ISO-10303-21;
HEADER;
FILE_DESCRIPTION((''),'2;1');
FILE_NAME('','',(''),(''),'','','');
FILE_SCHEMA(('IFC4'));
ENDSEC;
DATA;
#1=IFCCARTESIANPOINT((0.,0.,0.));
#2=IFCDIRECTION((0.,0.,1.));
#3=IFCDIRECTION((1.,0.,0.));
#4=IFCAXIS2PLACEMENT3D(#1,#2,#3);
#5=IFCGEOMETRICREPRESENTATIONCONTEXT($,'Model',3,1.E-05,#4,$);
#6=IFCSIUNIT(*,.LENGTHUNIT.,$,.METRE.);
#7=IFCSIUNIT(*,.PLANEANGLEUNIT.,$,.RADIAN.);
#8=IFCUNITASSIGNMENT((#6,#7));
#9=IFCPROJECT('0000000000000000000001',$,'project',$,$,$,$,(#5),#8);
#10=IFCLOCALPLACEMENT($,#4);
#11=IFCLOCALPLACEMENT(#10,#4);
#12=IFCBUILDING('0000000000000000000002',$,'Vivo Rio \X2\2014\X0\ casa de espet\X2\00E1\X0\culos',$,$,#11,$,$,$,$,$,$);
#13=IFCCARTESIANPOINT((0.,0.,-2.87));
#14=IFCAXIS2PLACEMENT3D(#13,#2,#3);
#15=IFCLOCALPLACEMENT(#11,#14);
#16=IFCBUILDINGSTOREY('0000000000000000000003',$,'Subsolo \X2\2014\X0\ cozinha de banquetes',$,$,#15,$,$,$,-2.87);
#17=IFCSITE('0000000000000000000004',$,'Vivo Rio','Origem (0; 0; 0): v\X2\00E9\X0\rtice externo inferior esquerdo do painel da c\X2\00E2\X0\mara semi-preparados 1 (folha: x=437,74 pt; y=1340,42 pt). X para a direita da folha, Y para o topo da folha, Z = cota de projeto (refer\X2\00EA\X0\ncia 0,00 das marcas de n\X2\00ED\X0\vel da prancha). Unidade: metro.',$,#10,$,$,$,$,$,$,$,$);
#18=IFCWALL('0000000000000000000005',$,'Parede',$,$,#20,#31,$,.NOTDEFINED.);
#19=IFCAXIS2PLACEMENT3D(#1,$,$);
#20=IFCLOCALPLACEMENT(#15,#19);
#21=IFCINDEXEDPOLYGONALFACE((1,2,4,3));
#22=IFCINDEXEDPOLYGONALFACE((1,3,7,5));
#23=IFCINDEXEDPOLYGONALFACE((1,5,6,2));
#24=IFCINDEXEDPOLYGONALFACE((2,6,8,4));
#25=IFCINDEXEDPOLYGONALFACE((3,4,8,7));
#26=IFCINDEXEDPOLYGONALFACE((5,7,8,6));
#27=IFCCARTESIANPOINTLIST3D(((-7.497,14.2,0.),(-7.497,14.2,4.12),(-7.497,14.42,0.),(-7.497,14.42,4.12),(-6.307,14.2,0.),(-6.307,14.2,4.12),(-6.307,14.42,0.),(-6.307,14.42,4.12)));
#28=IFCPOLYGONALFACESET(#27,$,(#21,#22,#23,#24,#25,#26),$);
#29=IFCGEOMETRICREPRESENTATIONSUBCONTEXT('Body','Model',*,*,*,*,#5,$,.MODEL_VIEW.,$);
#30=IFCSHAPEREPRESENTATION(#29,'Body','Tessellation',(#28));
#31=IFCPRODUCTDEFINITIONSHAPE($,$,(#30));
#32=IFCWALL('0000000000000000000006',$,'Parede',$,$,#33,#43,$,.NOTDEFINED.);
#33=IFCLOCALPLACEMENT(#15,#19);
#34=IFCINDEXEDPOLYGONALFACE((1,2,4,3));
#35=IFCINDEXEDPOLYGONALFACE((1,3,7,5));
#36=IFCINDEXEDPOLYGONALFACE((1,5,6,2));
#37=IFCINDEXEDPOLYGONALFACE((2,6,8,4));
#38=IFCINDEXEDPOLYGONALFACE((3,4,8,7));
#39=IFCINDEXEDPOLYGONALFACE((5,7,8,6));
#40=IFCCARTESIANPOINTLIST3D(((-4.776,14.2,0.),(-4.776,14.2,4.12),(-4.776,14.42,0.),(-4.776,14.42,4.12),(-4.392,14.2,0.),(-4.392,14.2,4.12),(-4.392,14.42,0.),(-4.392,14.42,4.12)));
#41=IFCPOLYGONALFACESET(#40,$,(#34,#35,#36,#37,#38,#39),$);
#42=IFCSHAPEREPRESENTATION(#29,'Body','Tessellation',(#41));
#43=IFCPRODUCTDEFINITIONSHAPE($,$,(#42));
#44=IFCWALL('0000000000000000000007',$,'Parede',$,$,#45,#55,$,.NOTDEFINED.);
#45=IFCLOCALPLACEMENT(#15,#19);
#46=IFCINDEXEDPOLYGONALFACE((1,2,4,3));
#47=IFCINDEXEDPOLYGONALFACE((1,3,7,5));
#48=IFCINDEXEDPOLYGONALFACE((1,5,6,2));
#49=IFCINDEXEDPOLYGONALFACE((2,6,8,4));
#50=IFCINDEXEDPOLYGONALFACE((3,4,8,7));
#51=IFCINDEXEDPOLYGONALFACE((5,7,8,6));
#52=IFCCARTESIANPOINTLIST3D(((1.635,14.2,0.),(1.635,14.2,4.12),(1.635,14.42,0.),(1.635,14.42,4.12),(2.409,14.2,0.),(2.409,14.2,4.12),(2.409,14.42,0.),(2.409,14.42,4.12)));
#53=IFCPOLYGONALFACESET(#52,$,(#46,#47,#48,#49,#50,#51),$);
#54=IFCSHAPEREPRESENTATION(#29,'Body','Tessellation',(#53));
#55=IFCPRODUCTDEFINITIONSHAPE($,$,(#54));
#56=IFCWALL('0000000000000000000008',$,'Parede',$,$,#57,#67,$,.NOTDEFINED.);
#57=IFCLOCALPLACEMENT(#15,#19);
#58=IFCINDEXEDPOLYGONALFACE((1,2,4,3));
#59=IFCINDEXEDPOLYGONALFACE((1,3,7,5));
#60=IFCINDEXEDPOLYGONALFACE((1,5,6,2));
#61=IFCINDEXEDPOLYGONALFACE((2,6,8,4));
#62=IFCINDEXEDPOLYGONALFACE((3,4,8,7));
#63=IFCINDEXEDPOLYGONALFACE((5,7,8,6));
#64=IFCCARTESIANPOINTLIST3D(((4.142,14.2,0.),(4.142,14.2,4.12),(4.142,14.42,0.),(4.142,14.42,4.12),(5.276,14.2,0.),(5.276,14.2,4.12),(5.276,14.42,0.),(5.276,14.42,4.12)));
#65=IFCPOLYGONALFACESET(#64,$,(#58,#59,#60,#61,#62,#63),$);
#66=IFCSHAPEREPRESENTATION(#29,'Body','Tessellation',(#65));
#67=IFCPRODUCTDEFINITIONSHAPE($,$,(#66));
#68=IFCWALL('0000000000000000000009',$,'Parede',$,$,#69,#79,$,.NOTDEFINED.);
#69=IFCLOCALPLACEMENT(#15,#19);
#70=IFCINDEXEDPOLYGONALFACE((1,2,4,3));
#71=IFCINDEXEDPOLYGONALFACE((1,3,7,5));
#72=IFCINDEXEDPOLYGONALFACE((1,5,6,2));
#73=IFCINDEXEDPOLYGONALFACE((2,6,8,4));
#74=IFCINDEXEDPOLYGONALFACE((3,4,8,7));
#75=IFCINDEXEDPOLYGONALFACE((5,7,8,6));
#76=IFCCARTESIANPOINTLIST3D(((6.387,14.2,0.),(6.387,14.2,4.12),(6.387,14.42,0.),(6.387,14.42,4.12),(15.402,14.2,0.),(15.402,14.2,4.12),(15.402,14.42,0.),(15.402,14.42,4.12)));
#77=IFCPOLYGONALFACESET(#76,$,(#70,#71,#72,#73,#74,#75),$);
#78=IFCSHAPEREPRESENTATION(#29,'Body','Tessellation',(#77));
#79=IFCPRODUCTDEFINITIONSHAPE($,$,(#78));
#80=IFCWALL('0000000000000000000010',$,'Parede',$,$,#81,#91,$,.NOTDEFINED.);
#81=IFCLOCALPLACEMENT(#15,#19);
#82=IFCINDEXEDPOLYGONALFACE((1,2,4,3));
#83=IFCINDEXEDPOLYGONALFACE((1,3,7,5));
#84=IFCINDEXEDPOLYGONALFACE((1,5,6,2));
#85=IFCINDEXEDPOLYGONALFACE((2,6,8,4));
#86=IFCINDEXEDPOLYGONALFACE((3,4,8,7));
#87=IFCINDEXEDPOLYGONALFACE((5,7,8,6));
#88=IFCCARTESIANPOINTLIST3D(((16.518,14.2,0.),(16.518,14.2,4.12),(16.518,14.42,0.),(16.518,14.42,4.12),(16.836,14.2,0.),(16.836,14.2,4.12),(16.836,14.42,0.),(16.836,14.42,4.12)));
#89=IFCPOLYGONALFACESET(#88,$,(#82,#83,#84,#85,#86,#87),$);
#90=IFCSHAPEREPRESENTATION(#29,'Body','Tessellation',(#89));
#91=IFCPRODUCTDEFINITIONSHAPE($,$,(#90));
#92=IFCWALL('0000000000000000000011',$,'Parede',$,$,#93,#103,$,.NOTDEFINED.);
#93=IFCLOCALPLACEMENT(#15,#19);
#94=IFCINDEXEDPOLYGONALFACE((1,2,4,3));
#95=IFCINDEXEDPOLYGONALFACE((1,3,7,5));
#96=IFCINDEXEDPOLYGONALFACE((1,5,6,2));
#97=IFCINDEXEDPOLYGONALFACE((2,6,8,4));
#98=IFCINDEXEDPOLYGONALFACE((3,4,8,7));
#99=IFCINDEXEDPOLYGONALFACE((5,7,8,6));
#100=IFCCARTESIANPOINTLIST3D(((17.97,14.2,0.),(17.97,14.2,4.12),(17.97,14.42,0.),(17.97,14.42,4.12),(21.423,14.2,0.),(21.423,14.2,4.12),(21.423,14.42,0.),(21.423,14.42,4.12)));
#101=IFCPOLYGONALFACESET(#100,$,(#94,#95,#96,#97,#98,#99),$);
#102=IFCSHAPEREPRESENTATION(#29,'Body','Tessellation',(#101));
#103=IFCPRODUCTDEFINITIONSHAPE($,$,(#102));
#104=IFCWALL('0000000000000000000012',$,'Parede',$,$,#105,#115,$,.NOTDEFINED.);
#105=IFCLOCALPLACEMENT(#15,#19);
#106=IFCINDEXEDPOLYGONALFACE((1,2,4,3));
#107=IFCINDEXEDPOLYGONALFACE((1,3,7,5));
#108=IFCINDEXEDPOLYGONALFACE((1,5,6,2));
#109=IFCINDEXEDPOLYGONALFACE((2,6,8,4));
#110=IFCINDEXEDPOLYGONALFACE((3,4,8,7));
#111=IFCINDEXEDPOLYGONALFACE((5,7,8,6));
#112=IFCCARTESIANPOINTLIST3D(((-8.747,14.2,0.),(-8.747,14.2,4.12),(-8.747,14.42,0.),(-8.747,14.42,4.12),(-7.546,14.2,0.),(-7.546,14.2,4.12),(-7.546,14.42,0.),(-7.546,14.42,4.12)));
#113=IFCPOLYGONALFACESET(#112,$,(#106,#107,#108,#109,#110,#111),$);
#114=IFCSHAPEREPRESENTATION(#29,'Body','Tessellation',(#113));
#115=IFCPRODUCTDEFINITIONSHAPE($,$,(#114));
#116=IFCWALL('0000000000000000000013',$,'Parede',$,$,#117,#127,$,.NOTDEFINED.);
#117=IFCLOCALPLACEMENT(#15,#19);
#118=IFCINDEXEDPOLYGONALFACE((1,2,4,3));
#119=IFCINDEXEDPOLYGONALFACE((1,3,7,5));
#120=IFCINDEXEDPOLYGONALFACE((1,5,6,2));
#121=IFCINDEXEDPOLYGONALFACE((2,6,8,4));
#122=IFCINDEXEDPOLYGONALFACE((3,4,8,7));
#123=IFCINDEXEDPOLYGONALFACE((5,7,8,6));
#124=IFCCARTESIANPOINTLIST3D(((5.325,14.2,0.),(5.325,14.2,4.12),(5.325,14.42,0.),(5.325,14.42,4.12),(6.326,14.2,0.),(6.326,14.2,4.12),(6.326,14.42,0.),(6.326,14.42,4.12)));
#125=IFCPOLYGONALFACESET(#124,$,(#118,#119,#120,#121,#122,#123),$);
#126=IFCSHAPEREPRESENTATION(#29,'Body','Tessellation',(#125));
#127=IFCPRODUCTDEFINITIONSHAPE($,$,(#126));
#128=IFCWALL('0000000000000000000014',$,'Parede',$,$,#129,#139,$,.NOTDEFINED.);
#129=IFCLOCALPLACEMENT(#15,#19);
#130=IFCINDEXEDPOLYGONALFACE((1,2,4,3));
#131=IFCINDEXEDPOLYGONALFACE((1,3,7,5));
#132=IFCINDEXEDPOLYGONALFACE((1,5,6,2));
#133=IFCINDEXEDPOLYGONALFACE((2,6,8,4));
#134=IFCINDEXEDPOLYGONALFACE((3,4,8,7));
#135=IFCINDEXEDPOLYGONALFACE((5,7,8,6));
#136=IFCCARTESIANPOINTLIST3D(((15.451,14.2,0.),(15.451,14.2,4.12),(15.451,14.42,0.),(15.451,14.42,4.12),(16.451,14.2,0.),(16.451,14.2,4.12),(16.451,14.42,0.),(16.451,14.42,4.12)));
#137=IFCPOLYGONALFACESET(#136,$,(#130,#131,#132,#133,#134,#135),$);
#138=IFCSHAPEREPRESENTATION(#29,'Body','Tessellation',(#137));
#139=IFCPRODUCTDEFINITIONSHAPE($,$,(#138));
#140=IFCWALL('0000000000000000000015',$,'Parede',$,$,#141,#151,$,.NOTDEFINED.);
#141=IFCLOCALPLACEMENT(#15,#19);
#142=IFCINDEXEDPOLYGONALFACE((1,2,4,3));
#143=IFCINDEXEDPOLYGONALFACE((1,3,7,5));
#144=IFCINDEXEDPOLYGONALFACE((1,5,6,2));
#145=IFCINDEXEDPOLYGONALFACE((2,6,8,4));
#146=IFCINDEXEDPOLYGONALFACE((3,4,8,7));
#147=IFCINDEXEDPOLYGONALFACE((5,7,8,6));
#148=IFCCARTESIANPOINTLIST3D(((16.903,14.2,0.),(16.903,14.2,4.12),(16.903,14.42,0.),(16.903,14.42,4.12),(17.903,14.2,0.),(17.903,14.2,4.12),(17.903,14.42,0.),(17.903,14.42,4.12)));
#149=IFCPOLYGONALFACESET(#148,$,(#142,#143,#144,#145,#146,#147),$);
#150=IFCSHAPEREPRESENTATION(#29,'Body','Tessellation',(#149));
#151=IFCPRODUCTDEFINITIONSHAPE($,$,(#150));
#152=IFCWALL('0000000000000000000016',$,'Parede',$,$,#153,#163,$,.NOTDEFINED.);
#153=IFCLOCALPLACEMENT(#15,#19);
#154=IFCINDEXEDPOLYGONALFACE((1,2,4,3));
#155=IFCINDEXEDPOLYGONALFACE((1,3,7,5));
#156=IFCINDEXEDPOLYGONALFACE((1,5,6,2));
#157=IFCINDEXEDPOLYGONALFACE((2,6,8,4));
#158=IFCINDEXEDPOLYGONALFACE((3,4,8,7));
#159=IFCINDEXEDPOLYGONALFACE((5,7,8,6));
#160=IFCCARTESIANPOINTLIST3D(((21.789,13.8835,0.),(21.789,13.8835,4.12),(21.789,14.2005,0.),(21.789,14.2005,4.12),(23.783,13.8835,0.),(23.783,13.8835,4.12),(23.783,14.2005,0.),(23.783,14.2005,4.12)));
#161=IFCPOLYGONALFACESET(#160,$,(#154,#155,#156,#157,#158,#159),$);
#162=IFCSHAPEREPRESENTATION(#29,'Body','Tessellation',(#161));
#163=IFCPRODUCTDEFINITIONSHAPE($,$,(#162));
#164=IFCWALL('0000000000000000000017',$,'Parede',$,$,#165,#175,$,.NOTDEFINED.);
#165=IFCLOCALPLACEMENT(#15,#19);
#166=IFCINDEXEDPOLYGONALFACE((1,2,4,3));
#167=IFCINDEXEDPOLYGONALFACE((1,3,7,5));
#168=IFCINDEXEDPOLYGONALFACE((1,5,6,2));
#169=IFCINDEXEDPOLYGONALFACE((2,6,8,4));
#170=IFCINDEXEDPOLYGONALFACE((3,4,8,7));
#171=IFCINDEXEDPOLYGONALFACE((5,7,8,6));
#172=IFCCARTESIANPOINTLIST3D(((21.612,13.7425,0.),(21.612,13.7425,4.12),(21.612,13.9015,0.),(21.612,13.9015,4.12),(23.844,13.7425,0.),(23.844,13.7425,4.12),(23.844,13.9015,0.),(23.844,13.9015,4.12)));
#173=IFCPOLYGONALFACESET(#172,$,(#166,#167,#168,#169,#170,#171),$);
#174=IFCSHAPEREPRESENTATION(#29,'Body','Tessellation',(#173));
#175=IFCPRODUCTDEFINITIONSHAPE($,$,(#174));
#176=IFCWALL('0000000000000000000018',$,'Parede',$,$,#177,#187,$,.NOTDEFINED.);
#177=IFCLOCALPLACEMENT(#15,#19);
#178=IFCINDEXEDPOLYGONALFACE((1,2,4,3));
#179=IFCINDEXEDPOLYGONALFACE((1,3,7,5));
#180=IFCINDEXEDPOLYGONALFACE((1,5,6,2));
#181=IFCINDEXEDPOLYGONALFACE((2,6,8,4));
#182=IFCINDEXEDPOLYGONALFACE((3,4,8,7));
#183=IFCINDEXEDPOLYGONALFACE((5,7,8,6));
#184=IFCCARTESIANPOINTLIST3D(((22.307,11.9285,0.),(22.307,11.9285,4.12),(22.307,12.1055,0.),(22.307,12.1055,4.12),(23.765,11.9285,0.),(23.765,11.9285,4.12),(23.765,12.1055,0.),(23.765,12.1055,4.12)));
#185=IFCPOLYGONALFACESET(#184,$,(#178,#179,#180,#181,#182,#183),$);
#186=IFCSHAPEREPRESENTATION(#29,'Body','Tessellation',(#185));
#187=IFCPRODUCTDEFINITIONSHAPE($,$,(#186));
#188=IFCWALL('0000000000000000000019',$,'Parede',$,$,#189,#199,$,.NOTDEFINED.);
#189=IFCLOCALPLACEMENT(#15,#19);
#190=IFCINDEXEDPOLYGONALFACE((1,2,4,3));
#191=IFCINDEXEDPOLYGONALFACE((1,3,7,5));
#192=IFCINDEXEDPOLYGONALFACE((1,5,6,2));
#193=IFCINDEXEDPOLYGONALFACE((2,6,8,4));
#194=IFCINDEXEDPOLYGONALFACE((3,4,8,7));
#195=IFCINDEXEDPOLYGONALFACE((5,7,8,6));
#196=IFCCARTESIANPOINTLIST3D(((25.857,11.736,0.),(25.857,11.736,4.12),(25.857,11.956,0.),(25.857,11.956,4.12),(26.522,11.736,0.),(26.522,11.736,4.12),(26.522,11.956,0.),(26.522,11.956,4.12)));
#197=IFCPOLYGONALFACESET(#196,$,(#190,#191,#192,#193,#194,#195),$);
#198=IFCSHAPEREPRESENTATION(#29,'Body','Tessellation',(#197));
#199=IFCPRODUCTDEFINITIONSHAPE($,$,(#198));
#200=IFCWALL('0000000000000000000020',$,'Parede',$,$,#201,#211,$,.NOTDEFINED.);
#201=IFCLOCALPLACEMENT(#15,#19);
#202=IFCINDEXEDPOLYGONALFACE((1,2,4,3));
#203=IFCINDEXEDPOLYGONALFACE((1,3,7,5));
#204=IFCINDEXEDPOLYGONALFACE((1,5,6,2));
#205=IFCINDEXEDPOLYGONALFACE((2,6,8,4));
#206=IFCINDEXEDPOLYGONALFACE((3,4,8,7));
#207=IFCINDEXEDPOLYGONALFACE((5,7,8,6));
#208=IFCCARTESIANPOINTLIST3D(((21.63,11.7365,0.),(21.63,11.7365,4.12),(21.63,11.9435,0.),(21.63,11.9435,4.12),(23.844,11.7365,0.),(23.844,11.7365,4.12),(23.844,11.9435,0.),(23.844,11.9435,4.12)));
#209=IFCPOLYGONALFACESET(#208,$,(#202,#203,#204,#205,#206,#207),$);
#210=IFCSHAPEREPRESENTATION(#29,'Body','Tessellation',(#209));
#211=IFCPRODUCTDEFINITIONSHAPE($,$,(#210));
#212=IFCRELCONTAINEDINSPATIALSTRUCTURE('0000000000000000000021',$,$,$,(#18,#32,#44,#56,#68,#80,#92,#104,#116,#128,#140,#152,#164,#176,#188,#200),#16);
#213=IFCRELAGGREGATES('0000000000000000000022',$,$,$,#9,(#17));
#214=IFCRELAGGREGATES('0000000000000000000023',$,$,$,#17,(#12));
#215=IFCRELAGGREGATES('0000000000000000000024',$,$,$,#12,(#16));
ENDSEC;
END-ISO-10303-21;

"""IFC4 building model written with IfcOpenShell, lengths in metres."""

from ifc_helpers import new_model, si_unit, frame, origin_with_axes, origin_2d, place, context, subcontext, project, spatial, rectangle, extrude, element, save


model = new_model("IFC4")

# Units and contexts
model_context = context("Model", 3, precision=1e-05, world=origin_with_axes())
body_context = subcontext(model_context, "Body", "Model", "MODEL_VIEW")
ifc_project = project(units=[si_unit("LENGTHUNIT", "METRE"), si_unit("PLANEANGLEUNIT", "RADIAN")], contexts=[model_context])

# Site, building, storey
site_placement = place(None, origin_with_axes())
site = spatial("IfcSite", under=ifc_project, at=site_placement, Name="Vivo Rio", Description="Origem (0; 0; 0): vértice externo inferior esquerdo do painel da câmara semi-preparados 1 (folha: x=437,74 pt; y=1340,42 pt). X para a direita da folha, Y para o topo da folha, Z = cota de projeto (referência 0,00 das marcas de nível da prancha). Unidade: metro.")
building_placement = place(site_placement, origin_with_axes())
building = spatial("IfcBuilding", under=site, at=building_placement, Name="Vivo Rio — casa de espetáculos")
storey_placement = place(building_placement, frame((0.0, 0.0, -2.87), z_axis=(0.0, 0.0, 1.0), x_axis=(1.0, 0.0, 0.0)))
storey = spatial("IfcBuildingStorey", under=building, at=storey_placement, Name="Subsolo — cozinha de banquetes", Elevation=-2.87)

# Walls
wall_1_placement = place(storey_placement, origin_with_axes())
element("IfcWall", 1, at=wall_1_placement, inside=storey, Name="Parede", PredefinedType="NOTDEFINED", context=body_context, shape_type="SweptSolid", body=[
    extrude(rectangle(XDim=1.19, YDim=0.22, at=origin_2d()), frame((-6.902, 14.31, 0.0), z_axis=(0.0, 0.0, 1.0), x_axis=(1.0, 0.0, 0.0)), (0.0, 0.0, 1.0), 4.12),
])
wall_2_placement = place(storey_placement, origin_with_axes())
element("IfcWall", 2, at=wall_2_placement, inside=storey, Name="Parede", PredefinedType="NOTDEFINED", context=body_context, shape_type="SweptSolid", body=[
    extrude(rectangle(XDim=0.384, YDim=0.22, at=origin_2d()), frame((-4.584, 14.31, 0.0), z_axis=(0.0, 0.0, 1.0), x_axis=(1.0, 0.0, 0.0)), (0.0, 0.0, 1.0), 4.12),
])
wall_3_placement = place(storey_placement, origin_with_axes())
element("IfcWall", 3, at=wall_3_placement, inside=storey, Name="Parede", PredefinedType="NOTDEFINED", context=body_context, shape_type="SweptSolid", body=[
    extrude(rectangle(XDim=0.774, YDim=0.22, at=origin_2d()), frame((2.022, 14.31, 0.0), z_axis=(0.0, 0.0, 1.0), x_axis=(1.0, 0.0, 0.0)), (0.0, 0.0, 1.0), 4.12),
])
wall_4_placement = place(storey_placement, origin_with_axes())
element("IfcWall", 4, at=wall_4_placement, inside=storey, Name="Parede", PredefinedType="NOTDEFINED", context=body_context, shape_type="SweptSolid", body=[
    extrude(rectangle(XDim=1.134, YDim=0.22, at=origin_2d()), frame((4.709, 14.31, 0.0), z_axis=(0.0, 0.0, 1.0), x_axis=(1.0, 0.0, 0.0)), (0.0, 0.0, 1.0), 4.12),
])
wall_5_placement = place(storey_placement, origin_with_axes())
element("IfcWall", 5, at=wall_5_placement, inside=storey, Name="Parede", PredefinedType="NOTDEFINED", context=body_context, shape_type="SweptSolid", body=[
    extrude(rectangle(XDim=9.015, YDim=0.22, at=origin_2d()), frame((10.8945, 14.31, 0.0), z_axis=(0.0, 0.0, 1.0), x_axis=(1.0, 0.0, 0.0)), (0.0, 0.0, 1.0), 4.12),
])
wall_6_placement = place(storey_placement, origin_with_axes())
element("IfcWall", 6, at=wall_6_placement, inside=storey, Name="Parede", PredefinedType="NOTDEFINED", context=body_context, shape_type="SweptSolid", body=[
    extrude(rectangle(XDim=0.318, YDim=0.22, at=origin_2d()), frame((16.677, 14.31, 0.0), z_axis=(0.0, 0.0, 1.0), x_axis=(1.0, 0.0, 0.0)), (0.0, 0.0, 1.0), 4.12),
])
wall_7_placement = place(storey_placement, origin_with_axes())
element("IfcWall", 7, at=wall_7_placement, inside=storey, Name="Parede", PredefinedType="NOTDEFINED", context=body_context, shape_type="SweptSolid", body=[
    extrude(rectangle(XDim=3.453, YDim=0.22, at=origin_2d()), frame((19.6965, 14.31, 0.0), z_axis=(0.0, 0.0, 1.0), x_axis=(1.0, 0.0, 0.0)), (0.0, 0.0, 1.0), 4.12),
])
wall_8_placement = place(storey_placement, origin_with_axes())
element("IfcWall", 8, at=wall_8_placement, inside=storey, Name="Parede", PredefinedType="NOTDEFINED", context=body_context, shape_type="SweptSolid", body=[
    extrude(rectangle(XDim=1.201, YDim=0.22, at=origin_2d()), frame((-8.1465, 14.31, 0.0), z_axis=(0.0, 0.0, 1.0), x_axis=(1.0, 0.0, 0.0)), (0.0, 0.0, 1.0), 4.12),
])
wall_9_placement = place(storey_placement, origin_with_axes())
element("IfcWall", 9, at=wall_9_placement, inside=storey, Name="Parede", PredefinedType="NOTDEFINED", context=body_context, shape_type="SweptSolid", body=[
    extrude(rectangle(XDim=1.001, YDim=0.22, at=origin_2d()), frame((5.8255, 14.31, 0.0), z_axis=(0.0, 0.0, 1.0), x_axis=(1.0, 0.0, 0.0)), (0.0, 0.0, 1.0), 4.12),
])
wall_10_placement = place(storey_placement, origin_with_axes())
element("IfcWall", 10, at=wall_10_placement, inside=storey, Name="Parede", PredefinedType="NOTDEFINED", context=body_context, shape_type="SweptSolid", body=[
    extrude(rectangle(XDim=1.0, YDim=0.22, at=origin_2d()), frame((15.951, 14.31, 0.0), z_axis=(0.0, 0.0, 1.0), x_axis=(1.0, 0.0, 0.0)), (0.0, 0.0, 1.0), 4.12),
])
wall_11_placement = place(storey_placement, origin_with_axes())
element("IfcWall", 11, at=wall_11_placement, inside=storey, Name="Parede", PredefinedType="NOTDEFINED", context=body_context, shape_type="SweptSolid", body=[
    extrude(rectangle(XDim=1.0, YDim=0.22, at=origin_2d()), frame((17.403, 14.31, 0.0), z_axis=(0.0, 0.0, 1.0), x_axis=(1.0, 0.0, 0.0)), (0.0, 0.0, 1.0), 4.12),
])
wall_12_placement = place(storey_placement, origin_with_axes())
element("IfcWall", 12, at=wall_12_placement, inside=storey, Name="Parede", PredefinedType="NOTDEFINED", context=body_context, shape_type="SweptSolid", body=[
    extrude(rectangle(XDim=1.994, YDim=0.317, at=origin_2d()), frame((22.786, 14.042, 0.0), z_axis=(0.0, 0.0, 1.0), x_axis=(1.0, 0.0, 0.0)), (0.0, 0.0, 1.0), 4.12),
])
wall_13_placement = place(storey_placement, origin_with_axes())
element("IfcWall", 13, at=wall_13_placement, inside=storey, Name="Parede", PredefinedType="NOTDEFINED", context=body_context, shape_type="SweptSolid", body=[
    extrude(rectangle(XDim=2.232, YDim=0.159, at=origin_2d()), frame((22.728, 13.822, 0.0), z_axis=(0.0, 0.0, 1.0), x_axis=(1.0, 0.0, 0.0)), (0.0, 0.0, 1.0), 4.12),
])
wall_14_placement = place(storey_placement, origin_with_axes())
element("IfcWall", 14, at=wall_14_placement, inside=storey, Name="Parede", PredefinedType="NOTDEFINED", context=body_context, shape_type="SweptSolid", body=[
    extrude(rectangle(XDim=1.458, YDim=0.177, at=origin_2d()), frame((23.036, 12.017, 0.0), z_axis=(0.0, 0.0, 1.0), x_axis=(1.0, 0.0, 0.0)), (0.0, 0.0, 1.0), 4.12),
])
wall_15_placement = place(storey_placement, origin_with_axes())
element("IfcWall", 15, at=wall_15_placement, inside=storey, Name="Parede", PredefinedType="NOTDEFINED", context=body_context, shape_type="SweptSolid", body=[
    extrude(rectangle(XDim=0.665, YDim=0.22, at=origin_2d()), frame((26.1895, 11.846, 0.0), z_axis=(0.0, 0.0, 1.0), x_axis=(1.0, 0.0, 0.0)), (0.0, 0.0, 1.0), 4.12),
])
wall_16_placement = place(storey_placement, origin_with_axes())
element("IfcWall", 16, at=wall_16_placement, inside=storey, Name="Parede", PredefinedType="NOTDEFINED", context=body_context, shape_type="SweptSolid", body=[
    extrude(rectangle(XDim=2.214, YDim=0.207, at=origin_2d()), frame((22.737, 11.84, 0.0), z_axis=(0.0, 0.0, 1.0), x_axis=(1.0, 0.0, 0.0)), (0.0, 0.0, 1.0), 4.12),
])

save(model, "model.ifc")
